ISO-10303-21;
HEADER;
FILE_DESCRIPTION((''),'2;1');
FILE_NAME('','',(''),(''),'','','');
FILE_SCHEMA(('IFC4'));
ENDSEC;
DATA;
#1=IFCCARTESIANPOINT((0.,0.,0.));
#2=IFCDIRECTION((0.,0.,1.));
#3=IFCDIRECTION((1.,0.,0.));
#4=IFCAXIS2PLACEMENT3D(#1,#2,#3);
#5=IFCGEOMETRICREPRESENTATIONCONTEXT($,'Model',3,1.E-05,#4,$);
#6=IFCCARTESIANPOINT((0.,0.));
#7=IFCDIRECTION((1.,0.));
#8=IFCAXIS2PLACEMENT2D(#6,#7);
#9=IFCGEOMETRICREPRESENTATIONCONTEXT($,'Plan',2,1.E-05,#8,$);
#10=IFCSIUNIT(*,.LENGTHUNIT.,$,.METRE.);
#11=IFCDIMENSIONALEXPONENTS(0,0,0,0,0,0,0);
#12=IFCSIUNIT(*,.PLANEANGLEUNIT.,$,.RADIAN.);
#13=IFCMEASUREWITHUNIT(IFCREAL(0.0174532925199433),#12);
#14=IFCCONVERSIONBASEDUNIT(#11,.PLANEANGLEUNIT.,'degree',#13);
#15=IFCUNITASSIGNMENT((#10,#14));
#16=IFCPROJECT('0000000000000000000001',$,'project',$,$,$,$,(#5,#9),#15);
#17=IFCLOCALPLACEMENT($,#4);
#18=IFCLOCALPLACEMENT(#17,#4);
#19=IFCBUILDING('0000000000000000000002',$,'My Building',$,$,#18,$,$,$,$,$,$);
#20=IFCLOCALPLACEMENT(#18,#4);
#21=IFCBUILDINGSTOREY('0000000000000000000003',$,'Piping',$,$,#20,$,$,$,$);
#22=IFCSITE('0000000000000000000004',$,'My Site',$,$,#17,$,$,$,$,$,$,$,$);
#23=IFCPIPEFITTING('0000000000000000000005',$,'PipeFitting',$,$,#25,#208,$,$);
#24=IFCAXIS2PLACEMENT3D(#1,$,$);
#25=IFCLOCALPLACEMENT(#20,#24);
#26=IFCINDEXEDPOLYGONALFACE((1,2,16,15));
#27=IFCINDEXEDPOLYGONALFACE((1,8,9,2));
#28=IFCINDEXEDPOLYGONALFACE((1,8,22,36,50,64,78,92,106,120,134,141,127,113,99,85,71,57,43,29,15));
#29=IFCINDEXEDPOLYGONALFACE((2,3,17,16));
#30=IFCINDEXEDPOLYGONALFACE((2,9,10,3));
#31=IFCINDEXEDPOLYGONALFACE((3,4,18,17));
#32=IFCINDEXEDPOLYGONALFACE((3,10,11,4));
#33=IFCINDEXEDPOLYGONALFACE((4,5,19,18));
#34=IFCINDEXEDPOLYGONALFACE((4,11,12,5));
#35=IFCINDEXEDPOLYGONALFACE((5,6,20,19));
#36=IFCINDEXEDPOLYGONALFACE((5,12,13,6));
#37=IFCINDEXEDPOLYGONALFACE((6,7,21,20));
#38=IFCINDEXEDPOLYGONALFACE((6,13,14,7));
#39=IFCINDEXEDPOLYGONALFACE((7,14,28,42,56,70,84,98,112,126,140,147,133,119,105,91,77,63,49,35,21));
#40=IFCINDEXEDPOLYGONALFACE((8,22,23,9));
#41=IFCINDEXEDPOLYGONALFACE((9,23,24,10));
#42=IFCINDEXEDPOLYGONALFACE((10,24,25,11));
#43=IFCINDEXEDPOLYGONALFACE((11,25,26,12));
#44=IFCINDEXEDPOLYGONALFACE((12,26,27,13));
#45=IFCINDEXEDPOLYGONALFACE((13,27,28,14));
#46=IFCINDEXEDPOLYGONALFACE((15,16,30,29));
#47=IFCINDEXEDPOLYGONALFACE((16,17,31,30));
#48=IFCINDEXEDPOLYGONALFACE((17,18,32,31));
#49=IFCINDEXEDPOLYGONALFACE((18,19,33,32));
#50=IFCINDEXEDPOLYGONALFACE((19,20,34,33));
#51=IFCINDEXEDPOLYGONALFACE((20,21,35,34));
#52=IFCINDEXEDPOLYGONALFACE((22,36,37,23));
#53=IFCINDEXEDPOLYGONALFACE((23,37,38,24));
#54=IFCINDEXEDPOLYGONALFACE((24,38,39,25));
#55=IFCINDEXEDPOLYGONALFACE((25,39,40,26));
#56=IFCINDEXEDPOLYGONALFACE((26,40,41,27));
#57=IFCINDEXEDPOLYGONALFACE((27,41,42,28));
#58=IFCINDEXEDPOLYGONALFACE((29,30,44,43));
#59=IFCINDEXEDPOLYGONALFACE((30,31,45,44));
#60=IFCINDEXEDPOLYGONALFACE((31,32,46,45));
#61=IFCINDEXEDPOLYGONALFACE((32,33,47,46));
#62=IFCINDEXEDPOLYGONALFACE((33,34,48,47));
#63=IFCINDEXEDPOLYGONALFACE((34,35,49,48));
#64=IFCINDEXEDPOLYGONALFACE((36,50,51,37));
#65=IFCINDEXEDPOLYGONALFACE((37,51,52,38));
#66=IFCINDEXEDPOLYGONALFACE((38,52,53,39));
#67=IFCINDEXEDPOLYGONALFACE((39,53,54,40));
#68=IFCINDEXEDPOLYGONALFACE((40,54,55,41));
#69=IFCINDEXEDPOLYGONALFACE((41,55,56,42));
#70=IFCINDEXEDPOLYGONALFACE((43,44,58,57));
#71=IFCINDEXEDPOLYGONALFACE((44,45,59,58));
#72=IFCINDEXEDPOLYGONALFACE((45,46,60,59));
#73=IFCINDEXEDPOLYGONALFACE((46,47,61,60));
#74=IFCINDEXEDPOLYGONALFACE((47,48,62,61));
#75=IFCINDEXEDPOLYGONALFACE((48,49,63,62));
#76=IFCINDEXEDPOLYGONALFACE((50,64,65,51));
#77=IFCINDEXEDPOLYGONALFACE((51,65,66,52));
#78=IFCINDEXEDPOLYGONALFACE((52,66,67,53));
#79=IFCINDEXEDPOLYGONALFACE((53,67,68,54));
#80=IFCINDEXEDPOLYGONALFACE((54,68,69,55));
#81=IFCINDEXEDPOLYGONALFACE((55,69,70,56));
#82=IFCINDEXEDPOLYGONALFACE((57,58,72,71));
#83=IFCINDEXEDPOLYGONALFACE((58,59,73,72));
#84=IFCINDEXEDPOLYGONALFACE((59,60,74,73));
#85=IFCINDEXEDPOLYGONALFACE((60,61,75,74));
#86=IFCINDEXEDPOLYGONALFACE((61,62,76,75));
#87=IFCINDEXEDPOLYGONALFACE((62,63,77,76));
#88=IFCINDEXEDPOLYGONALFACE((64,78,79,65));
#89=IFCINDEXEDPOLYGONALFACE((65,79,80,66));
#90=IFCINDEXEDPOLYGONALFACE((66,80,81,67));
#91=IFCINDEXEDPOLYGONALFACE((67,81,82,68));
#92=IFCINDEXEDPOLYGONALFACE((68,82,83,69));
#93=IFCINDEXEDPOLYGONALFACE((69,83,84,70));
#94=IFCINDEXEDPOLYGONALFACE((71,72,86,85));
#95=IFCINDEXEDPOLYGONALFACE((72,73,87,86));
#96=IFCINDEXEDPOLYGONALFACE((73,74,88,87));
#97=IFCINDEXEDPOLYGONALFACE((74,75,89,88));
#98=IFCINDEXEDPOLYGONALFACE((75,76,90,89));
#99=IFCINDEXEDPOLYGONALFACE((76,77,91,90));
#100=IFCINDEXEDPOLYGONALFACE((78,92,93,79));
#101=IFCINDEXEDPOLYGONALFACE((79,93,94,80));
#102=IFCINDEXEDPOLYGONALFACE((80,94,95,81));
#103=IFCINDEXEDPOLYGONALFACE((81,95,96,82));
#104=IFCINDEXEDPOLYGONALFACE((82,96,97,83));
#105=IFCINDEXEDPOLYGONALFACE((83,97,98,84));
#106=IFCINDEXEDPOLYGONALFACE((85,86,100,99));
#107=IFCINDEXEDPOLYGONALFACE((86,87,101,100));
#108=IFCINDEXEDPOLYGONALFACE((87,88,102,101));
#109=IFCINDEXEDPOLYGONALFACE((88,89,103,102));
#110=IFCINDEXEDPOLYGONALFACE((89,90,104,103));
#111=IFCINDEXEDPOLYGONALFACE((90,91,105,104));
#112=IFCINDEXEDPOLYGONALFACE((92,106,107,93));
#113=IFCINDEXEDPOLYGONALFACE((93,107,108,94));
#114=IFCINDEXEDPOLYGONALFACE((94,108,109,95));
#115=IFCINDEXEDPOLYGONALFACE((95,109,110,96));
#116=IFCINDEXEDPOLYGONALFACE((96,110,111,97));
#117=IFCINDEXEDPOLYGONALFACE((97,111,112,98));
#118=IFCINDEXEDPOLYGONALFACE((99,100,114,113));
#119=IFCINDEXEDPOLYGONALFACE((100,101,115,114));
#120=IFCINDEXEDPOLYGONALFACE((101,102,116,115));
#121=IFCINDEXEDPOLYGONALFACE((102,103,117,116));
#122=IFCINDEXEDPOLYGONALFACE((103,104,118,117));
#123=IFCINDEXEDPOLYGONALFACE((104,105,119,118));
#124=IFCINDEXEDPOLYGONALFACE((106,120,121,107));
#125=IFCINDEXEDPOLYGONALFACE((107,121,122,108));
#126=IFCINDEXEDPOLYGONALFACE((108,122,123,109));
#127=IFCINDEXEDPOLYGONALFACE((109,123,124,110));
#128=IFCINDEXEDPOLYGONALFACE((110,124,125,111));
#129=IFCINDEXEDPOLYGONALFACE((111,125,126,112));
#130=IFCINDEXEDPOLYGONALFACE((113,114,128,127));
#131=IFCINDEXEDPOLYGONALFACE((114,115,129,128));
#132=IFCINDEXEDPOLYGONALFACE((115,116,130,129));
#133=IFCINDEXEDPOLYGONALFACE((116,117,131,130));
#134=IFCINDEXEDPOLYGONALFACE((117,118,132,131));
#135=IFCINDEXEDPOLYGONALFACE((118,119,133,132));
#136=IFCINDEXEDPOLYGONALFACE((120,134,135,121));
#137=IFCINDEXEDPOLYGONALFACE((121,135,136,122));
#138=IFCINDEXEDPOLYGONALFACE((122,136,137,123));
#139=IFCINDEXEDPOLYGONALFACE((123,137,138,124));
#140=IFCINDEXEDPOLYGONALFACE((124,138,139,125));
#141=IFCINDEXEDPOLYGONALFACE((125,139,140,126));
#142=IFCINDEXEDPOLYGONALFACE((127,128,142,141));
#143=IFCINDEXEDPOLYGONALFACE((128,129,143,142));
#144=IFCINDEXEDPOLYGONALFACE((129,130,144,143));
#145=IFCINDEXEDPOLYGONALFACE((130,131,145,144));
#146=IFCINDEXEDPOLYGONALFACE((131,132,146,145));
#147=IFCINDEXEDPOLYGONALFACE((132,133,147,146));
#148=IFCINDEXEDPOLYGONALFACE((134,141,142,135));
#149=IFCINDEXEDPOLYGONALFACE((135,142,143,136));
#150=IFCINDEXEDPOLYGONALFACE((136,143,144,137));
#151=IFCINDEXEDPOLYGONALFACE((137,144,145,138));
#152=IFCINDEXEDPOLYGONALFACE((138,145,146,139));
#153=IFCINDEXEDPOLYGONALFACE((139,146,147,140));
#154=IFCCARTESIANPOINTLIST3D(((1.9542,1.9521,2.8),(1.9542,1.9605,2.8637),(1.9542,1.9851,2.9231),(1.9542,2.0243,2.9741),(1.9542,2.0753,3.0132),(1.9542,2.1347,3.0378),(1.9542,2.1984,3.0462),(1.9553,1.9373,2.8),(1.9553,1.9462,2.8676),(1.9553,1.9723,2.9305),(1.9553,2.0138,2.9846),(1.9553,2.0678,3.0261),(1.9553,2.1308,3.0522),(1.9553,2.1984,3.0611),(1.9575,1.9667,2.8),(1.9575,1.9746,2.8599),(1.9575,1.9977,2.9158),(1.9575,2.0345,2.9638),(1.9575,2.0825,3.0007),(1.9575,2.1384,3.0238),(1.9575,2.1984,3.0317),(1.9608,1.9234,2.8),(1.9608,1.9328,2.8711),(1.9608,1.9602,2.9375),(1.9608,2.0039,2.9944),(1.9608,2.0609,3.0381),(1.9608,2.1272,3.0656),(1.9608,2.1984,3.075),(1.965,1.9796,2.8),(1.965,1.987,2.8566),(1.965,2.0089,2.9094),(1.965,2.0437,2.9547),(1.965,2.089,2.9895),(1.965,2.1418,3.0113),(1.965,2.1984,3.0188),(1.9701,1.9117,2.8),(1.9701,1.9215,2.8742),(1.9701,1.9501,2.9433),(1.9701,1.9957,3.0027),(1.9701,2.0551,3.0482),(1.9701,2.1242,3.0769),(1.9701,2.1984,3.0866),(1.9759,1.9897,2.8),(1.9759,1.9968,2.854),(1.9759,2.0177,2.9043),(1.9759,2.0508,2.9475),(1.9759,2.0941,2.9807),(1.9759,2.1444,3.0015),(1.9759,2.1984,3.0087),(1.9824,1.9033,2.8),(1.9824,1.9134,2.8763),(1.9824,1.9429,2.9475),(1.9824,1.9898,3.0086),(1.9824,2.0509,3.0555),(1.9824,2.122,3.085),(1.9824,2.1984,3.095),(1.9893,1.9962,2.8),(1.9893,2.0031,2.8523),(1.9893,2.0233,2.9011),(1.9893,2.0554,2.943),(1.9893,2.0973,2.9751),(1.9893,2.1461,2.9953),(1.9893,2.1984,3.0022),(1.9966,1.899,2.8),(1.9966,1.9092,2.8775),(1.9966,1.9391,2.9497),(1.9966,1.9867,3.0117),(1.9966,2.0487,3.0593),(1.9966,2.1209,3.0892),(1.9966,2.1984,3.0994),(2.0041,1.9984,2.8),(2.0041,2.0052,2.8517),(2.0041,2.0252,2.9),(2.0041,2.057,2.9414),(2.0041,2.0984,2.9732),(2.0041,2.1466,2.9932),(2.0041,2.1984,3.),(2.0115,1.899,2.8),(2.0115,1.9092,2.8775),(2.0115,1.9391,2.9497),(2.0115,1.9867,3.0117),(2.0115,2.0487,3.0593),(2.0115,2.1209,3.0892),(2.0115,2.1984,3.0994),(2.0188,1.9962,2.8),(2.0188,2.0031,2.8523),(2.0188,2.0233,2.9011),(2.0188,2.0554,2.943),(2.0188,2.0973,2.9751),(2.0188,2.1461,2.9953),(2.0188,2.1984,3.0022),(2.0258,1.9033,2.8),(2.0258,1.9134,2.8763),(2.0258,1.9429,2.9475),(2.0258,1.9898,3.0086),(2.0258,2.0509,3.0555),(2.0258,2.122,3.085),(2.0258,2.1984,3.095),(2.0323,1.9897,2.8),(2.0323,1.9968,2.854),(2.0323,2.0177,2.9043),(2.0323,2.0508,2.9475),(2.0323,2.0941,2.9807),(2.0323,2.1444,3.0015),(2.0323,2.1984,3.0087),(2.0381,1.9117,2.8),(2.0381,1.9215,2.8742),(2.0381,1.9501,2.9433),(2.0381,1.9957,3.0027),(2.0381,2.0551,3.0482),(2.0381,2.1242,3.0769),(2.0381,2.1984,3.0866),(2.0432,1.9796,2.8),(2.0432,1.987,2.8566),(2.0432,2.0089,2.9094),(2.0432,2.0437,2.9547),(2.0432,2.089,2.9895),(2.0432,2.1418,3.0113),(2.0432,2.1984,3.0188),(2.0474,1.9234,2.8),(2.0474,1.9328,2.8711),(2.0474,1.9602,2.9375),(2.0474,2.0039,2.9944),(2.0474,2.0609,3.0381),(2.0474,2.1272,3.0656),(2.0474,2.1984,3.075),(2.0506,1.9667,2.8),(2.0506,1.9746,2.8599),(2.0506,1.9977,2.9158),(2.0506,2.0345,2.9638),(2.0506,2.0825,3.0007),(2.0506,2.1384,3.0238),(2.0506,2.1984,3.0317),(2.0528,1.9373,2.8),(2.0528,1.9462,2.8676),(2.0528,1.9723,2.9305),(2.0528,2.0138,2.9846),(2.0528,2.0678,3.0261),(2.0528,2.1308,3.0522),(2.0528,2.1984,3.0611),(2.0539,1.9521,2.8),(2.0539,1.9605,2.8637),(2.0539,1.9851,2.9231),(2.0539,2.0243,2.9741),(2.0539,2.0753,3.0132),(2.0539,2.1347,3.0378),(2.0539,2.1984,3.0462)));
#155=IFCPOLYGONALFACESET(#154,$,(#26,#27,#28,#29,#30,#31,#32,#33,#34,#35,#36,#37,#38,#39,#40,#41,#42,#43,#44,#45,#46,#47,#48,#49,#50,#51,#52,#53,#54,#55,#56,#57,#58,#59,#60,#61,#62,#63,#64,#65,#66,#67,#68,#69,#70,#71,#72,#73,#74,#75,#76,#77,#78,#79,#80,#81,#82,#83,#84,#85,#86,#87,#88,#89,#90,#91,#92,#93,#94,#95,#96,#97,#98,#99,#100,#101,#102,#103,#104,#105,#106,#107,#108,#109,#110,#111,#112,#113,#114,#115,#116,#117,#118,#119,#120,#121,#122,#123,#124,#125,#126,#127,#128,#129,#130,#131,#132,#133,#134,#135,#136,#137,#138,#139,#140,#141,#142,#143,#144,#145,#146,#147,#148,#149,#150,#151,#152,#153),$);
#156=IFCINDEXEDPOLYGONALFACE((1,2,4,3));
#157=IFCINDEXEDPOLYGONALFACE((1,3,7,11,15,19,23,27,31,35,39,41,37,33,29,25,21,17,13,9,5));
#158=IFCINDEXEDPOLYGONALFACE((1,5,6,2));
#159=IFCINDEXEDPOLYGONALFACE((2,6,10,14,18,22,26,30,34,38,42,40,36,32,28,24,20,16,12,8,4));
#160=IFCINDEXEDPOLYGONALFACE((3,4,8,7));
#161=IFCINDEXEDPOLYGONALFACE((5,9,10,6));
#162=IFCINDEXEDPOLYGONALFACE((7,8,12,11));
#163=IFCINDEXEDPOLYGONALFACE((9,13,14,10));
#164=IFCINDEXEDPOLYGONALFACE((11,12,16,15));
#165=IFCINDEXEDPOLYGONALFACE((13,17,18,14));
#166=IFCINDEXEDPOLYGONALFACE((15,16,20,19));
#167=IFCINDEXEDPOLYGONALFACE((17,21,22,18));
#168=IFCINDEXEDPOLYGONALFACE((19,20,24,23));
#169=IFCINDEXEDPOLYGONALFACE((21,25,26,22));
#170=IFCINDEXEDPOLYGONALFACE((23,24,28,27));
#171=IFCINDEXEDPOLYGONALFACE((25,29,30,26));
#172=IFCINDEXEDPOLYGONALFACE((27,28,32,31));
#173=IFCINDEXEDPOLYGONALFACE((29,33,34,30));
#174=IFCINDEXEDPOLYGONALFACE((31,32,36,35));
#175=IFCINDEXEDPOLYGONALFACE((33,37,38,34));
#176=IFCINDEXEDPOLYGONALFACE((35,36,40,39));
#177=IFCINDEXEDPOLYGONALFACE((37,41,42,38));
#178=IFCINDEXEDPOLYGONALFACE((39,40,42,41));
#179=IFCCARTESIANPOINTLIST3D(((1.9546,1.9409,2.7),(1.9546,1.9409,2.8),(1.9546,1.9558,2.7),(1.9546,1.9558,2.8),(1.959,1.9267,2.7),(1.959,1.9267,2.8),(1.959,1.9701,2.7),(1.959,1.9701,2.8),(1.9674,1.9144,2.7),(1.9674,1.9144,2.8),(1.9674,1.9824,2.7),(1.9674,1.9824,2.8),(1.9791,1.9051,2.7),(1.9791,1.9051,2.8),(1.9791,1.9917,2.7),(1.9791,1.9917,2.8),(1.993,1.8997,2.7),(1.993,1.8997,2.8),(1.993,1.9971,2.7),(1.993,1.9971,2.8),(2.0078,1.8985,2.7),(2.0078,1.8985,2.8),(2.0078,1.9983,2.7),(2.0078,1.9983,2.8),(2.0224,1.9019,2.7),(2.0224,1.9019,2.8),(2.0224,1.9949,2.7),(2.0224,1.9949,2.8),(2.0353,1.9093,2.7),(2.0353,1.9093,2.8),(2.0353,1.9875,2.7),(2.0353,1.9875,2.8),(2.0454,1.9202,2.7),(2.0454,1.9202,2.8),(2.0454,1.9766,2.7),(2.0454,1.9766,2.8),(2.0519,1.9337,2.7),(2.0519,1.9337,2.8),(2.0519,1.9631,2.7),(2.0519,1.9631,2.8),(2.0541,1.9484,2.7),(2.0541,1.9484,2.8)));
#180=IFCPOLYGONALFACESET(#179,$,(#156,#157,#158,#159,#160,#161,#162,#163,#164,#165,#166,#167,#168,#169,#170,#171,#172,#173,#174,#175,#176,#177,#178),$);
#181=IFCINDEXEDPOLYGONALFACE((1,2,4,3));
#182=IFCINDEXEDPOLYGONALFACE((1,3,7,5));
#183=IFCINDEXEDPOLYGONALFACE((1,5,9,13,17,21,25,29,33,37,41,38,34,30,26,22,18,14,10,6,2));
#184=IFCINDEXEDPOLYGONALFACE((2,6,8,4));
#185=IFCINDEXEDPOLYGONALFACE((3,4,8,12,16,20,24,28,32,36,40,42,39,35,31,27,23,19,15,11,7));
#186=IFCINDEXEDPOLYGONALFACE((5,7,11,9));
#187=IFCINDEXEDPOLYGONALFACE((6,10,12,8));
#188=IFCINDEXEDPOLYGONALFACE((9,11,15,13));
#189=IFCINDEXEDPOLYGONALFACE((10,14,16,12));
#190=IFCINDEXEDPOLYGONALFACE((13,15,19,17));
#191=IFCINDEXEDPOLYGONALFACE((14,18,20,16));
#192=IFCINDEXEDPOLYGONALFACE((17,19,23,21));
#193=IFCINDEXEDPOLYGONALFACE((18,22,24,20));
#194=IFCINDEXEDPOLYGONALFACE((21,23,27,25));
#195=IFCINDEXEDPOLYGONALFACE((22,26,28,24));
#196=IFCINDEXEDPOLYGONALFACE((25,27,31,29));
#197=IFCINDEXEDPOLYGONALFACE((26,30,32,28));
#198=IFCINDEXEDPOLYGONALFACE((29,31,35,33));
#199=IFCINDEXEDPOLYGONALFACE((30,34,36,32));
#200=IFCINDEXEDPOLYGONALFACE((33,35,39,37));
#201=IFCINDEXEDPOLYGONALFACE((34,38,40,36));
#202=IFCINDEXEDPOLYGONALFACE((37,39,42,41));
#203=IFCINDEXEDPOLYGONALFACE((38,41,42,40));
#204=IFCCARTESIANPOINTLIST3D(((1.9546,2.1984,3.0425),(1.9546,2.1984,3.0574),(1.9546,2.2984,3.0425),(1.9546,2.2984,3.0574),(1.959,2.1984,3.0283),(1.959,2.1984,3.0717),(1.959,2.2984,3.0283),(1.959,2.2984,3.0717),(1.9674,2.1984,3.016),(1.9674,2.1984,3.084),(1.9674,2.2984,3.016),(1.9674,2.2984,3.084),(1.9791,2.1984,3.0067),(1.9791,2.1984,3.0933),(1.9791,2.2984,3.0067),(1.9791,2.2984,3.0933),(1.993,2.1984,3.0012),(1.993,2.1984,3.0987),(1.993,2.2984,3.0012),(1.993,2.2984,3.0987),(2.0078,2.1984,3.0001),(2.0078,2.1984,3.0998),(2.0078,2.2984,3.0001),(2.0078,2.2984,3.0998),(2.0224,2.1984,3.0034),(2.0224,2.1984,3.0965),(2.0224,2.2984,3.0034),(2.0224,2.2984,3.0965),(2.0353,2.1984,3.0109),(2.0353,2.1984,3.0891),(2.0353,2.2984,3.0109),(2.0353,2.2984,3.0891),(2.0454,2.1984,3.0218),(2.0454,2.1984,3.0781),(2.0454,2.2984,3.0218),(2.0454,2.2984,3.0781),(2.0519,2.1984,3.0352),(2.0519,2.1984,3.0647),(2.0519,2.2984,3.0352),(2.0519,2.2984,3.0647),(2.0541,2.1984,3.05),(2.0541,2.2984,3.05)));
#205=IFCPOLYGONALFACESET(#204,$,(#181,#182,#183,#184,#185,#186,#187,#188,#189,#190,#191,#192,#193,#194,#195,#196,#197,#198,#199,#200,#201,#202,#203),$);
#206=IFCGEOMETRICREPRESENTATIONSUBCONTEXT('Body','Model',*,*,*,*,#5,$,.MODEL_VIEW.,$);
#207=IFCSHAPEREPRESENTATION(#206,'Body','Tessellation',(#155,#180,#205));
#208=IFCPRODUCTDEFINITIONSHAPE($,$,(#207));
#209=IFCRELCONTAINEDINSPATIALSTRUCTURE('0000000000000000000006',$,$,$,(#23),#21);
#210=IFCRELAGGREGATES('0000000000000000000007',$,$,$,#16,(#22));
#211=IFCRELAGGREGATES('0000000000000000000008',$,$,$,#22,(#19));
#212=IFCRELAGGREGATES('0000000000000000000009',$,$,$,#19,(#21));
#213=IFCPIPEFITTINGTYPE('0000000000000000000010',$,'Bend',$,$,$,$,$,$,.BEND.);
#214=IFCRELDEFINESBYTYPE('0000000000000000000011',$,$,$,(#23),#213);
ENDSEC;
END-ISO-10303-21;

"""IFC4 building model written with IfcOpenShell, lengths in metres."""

from ifc_helpers import new_model, entity, si_unit, converted_unit, frame, origin_with_axes, origin_2d_with_axis, place, context, subcontext, project, spatial, circle, extrude, source, transform, mapped, type_object, type_shapes, element, save


model = new_model("IFC4")

# Units and contexts
model_context = context("Model", 3, precision=1e-05, world=origin_with_axes())
plan_context = context("Plan", 2, precision=1e-05, world=origin_2d_with_axis())
body_context = subcontext(model_context, "Body", "Model", "MODEL_VIEW")
ifc_project = project(units=[si_unit("LENGTHUNIT", "METRE"), converted_unit("PLANEANGLEUNIT", "degree", entity("IfcReal", 0.0174532925199433), si_unit("PLANEANGLEUNIT", "RADIAN"), dimensions=[0, 0, 0, 0, 0, 0, 0])], contexts=[model_context, plan_context])

# Site, building, storey
site_placement = place(None, origin_with_axes())
site = spatial("IfcSite", under=ifc_project, at=site_placement, Name="My Site")
building_placement = place(site_placement, origin_with_axes())
building = spatial("IfcBuilding", under=site, at=building_placement, Name="My Building")
storey_placement = place(building_placement, origin_with_axes())
storey = spatial("IfcBuildingStorey", under=building, at=storey_placement, Name="Piping")

# Pipe fitting
pipe_fitting_type_1 = type_object("IfcPipeFittingType", Name="Bend", PredefinedType="BEND")
shared_shape = source(origin_with_axes(), body_context, "Body", "SolidModel", [
    entity("IfcSweptDiskSolid", entity("IfcIndexedPolyCurve", entity("IfcCartesianPointList3D", [[0.0, 0.0, -0.1], [0.0, -0.0732, -0.2768], [0.0, -0.25, -0.35]]), [entity("IfcArcIndex", [1, 2, 3])]), 0.05),
    extrude(circle(Radius=0.05), origin_with_axes(), (0.0, 0.0, -1.0), 0.1),
    extrude(circle(Radius=0.05), frame((0.0, -0.25, -0.35), z_axis=(0.0, -1.0, 0.0), x_axis=(1.0, 0.0, 0.0)), (0.0, 0.0, 1.0), 0.1),
])
type_shapes(pipe_fitting_type_1, [shared_shape])
for number, where, z_axis, x_axis, name in (
    (1, (2.0041, 1.9484, 2.7), (0.0, 0.0, -1.0), (1.0, 0.0, 0.0), "PipeFitting"),
):
    element("IfcPipeFitting", number, at=place(storey_placement, frame(where, z_axis=z_axis, x_axis=x_axis)), inside=storey, type_object=pipe_fitting_type_1, Name=name, context=body_context, shape_type="MappedRepresentation", body=[
        mapped(shared_shape, transform((0.0, 0.0, 0.0), x_axis=(1.0, 0.0, 0.0), y_axis=(0.0, 1.0, 0.0), z_axis=(0.0, 0.0, 1.0), scale=1.0)),
    ])

save(model, "model.ifc")
